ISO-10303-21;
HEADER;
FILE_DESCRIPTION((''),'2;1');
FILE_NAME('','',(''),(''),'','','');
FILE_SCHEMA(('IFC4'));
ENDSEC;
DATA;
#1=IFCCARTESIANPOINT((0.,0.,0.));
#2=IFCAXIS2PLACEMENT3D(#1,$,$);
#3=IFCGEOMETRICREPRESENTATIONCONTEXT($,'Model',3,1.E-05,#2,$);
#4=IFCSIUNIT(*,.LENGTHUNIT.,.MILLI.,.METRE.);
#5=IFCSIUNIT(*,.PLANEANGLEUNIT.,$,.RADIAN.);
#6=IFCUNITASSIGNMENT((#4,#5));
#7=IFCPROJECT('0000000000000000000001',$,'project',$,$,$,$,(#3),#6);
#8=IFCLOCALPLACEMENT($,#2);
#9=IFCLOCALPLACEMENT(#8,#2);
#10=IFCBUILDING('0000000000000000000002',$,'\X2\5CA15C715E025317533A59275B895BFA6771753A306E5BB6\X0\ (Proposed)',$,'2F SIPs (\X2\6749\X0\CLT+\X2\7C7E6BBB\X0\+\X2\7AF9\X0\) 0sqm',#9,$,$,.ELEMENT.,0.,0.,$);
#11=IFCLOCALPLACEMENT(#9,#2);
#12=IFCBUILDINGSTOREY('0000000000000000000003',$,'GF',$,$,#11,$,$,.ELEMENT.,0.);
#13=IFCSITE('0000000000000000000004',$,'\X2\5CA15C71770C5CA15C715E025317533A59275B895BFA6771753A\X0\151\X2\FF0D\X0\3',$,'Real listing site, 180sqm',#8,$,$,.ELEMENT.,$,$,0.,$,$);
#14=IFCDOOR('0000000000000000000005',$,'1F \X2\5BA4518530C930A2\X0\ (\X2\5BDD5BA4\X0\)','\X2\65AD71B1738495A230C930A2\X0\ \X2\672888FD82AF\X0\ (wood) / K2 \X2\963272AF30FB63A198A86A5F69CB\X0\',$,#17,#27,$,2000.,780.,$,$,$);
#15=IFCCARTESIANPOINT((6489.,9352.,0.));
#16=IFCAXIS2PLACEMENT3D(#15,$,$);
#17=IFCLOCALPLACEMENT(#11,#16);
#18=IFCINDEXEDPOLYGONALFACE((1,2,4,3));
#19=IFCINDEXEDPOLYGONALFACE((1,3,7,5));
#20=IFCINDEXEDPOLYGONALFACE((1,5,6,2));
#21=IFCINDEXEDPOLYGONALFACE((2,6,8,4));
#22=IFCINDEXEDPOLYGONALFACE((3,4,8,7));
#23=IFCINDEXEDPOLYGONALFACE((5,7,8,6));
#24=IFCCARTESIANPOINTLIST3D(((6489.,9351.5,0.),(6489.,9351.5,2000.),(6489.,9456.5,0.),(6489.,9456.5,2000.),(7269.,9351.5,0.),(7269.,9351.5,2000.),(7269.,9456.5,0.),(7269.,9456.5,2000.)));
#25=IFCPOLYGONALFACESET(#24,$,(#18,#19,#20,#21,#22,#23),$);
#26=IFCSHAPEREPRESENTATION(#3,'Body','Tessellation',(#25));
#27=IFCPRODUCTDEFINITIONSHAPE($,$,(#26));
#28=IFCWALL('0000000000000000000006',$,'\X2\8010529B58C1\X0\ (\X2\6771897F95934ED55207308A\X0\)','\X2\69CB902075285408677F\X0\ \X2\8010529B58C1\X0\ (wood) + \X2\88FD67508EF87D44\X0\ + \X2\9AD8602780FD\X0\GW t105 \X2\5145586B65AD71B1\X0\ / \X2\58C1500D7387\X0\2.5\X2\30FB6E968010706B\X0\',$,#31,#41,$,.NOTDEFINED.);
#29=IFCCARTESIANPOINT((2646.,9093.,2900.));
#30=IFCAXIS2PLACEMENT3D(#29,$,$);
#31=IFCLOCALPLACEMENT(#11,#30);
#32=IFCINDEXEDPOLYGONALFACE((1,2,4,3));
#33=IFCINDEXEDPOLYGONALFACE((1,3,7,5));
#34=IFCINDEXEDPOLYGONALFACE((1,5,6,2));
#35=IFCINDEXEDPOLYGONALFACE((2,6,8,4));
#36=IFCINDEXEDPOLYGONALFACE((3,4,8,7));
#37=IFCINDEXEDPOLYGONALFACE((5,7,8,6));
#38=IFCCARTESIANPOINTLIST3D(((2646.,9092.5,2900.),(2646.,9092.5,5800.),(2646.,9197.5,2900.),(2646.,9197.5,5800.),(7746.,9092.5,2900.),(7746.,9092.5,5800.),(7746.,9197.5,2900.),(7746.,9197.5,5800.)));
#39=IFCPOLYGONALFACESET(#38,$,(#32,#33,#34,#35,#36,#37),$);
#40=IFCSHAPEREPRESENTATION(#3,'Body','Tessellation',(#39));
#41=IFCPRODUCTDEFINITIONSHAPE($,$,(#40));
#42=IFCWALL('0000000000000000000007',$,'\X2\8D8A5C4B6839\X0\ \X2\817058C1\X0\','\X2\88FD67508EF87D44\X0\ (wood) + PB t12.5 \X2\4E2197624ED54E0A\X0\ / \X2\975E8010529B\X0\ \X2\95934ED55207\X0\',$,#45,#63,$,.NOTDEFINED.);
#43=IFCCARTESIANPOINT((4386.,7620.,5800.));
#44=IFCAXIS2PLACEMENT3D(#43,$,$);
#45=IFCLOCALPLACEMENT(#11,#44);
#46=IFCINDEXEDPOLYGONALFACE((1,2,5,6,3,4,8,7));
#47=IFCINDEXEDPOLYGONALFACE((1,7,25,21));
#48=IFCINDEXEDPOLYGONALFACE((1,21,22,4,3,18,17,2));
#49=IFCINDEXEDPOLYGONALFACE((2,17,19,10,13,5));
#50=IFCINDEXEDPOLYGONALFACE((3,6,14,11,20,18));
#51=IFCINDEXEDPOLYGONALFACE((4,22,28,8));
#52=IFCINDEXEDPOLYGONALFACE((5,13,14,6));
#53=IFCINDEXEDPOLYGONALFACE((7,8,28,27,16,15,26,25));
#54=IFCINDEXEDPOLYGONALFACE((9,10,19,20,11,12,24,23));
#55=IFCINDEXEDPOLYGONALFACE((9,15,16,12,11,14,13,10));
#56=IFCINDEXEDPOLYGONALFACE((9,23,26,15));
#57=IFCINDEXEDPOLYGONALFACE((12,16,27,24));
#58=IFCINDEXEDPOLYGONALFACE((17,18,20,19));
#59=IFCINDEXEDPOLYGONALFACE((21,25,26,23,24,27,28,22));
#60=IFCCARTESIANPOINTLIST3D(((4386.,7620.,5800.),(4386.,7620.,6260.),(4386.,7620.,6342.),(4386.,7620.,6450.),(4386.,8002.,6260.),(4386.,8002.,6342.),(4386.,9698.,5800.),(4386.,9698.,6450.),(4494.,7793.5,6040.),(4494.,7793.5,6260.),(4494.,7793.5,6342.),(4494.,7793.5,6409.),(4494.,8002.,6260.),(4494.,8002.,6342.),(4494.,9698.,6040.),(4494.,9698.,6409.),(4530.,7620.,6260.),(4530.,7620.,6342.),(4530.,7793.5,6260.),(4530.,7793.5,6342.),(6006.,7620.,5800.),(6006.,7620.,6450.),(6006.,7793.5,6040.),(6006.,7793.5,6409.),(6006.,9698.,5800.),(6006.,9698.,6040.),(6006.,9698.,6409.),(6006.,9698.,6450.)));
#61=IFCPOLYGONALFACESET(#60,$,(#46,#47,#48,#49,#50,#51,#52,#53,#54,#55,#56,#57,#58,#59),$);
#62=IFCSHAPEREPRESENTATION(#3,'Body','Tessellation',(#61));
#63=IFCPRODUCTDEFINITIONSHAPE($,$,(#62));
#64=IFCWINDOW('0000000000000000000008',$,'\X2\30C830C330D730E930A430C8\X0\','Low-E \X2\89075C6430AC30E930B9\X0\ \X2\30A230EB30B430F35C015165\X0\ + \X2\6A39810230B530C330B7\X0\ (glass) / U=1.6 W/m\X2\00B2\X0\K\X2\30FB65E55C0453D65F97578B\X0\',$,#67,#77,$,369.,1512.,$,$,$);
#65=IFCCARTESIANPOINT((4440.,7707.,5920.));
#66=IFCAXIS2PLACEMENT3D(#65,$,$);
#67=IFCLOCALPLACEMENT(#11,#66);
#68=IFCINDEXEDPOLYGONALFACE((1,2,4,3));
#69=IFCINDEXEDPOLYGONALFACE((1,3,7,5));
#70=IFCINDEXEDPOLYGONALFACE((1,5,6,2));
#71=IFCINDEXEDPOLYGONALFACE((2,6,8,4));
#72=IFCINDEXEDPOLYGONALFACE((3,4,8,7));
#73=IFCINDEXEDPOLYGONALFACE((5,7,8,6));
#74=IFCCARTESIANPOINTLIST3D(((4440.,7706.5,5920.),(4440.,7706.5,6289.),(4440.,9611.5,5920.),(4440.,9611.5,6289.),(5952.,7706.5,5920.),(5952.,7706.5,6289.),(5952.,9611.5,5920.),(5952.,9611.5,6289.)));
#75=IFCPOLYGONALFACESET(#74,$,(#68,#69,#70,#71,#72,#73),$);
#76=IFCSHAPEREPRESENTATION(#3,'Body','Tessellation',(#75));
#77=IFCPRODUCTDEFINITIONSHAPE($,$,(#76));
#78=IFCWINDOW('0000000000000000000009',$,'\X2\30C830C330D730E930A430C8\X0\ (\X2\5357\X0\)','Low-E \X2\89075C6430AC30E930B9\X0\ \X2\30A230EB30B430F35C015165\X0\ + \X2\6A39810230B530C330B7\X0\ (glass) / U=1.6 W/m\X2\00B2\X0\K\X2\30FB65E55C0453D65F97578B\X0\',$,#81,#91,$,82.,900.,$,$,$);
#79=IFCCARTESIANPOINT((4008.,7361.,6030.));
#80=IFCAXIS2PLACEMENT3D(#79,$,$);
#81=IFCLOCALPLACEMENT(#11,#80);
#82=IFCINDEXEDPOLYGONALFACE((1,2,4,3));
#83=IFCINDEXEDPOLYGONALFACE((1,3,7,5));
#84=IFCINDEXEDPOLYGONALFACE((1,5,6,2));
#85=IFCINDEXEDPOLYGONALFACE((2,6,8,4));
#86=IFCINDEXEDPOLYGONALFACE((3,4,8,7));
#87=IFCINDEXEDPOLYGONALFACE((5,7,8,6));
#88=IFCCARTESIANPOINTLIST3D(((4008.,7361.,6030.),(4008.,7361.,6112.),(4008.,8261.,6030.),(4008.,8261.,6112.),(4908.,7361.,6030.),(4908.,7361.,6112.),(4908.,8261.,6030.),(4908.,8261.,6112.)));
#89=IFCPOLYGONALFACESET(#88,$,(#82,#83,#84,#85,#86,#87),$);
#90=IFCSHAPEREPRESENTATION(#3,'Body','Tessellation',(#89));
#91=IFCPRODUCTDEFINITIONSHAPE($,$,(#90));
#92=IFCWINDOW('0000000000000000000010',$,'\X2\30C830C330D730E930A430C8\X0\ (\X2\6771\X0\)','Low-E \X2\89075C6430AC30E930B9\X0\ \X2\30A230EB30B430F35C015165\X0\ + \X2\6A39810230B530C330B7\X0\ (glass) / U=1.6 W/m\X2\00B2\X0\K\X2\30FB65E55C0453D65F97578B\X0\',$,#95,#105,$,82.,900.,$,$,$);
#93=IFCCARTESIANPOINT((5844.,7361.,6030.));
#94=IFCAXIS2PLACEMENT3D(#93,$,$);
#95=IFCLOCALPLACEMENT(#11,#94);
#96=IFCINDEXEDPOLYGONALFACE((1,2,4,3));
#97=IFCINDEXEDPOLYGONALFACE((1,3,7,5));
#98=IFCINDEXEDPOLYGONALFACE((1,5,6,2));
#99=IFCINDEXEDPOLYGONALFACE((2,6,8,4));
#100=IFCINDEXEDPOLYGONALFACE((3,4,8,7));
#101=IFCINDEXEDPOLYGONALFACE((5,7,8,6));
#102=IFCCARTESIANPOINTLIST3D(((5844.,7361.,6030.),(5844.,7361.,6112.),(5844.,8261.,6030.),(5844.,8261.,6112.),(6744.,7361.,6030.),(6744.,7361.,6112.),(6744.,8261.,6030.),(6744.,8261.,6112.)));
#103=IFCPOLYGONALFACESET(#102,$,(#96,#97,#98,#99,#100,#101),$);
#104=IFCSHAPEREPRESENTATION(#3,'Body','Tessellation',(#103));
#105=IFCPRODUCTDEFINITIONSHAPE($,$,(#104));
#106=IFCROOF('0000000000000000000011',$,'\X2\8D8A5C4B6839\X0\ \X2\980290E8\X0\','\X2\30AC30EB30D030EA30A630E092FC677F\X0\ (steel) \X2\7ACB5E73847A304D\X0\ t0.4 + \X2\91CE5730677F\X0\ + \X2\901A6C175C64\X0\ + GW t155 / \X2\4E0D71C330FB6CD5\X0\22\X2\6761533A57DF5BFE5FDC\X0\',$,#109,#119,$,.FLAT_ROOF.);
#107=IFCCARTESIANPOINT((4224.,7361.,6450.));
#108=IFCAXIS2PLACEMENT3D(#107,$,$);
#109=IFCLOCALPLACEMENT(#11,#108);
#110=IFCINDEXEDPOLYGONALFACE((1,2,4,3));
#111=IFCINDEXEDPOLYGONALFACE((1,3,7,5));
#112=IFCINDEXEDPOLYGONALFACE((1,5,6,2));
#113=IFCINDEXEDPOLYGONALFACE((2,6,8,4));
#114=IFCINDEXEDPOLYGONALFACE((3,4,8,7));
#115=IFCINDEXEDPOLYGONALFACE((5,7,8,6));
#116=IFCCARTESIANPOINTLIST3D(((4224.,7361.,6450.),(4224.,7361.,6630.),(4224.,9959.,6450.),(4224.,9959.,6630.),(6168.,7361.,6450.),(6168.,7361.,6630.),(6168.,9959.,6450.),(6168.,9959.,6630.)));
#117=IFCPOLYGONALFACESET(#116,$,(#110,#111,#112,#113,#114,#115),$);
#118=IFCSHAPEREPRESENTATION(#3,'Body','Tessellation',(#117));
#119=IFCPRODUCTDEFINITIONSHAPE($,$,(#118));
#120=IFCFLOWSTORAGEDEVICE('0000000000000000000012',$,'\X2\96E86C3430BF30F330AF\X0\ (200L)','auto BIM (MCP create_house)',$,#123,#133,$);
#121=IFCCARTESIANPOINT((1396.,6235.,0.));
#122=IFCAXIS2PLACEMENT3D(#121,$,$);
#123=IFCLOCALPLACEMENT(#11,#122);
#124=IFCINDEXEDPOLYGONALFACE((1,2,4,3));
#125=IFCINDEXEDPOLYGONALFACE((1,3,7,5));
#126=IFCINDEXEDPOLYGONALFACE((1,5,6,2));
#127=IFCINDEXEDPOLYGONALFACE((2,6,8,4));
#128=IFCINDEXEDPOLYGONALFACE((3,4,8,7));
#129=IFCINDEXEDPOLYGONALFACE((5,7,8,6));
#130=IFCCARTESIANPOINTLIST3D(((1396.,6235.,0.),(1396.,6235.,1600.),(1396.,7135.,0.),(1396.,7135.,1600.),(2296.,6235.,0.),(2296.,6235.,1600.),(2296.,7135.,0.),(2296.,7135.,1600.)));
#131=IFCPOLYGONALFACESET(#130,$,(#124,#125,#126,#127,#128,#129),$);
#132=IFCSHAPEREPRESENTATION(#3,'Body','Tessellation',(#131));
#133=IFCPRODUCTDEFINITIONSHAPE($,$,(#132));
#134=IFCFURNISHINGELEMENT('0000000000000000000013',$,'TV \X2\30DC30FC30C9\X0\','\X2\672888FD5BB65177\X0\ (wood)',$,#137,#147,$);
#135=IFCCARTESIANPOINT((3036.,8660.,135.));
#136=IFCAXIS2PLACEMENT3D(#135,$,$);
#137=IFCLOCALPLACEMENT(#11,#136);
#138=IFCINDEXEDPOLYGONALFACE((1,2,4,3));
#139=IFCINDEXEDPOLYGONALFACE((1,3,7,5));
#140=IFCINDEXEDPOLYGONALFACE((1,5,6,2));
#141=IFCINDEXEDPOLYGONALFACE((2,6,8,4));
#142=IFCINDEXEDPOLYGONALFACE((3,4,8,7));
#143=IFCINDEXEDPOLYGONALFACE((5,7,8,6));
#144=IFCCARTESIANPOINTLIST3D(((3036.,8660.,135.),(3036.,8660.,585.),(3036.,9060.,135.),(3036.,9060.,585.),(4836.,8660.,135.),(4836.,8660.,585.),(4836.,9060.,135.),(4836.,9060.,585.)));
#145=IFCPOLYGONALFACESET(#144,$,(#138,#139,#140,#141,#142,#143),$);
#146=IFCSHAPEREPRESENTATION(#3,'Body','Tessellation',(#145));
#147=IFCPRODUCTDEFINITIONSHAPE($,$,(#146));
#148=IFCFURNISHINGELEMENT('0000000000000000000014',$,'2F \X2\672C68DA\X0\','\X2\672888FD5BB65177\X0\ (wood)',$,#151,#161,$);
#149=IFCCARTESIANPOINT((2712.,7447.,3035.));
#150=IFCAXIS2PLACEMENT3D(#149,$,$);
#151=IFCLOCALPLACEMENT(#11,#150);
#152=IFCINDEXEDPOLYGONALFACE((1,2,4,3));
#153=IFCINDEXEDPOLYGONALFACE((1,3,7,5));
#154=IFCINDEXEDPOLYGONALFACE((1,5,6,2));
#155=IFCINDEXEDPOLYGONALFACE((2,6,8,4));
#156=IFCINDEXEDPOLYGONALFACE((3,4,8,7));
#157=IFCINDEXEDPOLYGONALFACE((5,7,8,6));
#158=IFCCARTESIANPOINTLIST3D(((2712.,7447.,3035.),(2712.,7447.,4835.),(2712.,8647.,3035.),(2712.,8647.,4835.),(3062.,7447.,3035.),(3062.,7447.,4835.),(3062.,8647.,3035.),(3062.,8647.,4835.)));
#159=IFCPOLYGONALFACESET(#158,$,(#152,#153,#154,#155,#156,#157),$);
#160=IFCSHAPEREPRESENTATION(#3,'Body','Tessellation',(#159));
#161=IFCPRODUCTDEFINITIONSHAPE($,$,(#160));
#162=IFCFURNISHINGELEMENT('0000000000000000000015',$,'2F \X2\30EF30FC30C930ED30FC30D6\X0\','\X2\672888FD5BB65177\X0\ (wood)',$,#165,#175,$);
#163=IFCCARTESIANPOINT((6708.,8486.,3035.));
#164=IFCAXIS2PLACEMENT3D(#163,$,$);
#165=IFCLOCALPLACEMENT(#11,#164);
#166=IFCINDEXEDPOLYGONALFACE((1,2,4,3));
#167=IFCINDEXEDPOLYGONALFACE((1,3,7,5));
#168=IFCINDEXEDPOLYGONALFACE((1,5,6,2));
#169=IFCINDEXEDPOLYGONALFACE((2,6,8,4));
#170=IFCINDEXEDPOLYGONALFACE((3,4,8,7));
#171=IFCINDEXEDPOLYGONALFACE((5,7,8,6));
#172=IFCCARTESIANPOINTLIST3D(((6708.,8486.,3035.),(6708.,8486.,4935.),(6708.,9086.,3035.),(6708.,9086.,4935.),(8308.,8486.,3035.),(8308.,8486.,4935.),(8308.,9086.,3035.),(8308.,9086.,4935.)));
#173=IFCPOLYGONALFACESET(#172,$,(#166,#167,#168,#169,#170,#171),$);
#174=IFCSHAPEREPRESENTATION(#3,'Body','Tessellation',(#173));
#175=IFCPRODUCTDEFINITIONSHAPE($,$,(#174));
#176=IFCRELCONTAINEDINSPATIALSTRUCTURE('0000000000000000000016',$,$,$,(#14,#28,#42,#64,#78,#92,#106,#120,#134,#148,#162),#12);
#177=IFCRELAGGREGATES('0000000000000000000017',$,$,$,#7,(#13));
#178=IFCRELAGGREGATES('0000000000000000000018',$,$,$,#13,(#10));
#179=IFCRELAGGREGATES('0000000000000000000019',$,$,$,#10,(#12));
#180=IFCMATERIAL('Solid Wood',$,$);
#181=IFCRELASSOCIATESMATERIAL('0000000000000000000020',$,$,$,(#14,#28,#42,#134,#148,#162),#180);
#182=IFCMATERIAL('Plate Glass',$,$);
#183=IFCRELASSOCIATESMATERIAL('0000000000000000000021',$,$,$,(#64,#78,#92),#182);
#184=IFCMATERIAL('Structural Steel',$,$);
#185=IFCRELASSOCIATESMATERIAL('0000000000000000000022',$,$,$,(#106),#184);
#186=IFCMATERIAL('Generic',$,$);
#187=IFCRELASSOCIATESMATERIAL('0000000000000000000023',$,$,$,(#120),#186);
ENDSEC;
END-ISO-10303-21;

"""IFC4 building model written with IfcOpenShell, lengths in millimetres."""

from ifc_helpers import new_model, si_unit, frame, frame_2d, origin, place, context, project, spatial, rectangle, extrude, material, element, fill, save


model = new_model("IFC4")

# Units and contexts
model_context = context("Model", 3, precision=1e-05, world=origin())
ifc_project = project(units=[si_unit("LENGTHUNIT", "METRE", prefix="MILLI"), si_unit("PLANEANGLEUNIT", "RADIAN")], contexts=[model_context])

# Site, building, storey
site_placement = place(None, origin())
site = spatial("IfcSite", under=ifc_project, at=site_placement, Name="岡山県岡山市北区大安寺東町151－3", ObjectType="Real listing site, 180sqm", CompositionType="ELEMENT", RefElevation=0.0)
building_placement = place(site_placement, origin())
building = spatial("IfcBuilding", under=site, at=building_placement, Name="岡山市北区大安寺東町の家 (Proposed)", ObjectType="2F SIPs (杉CLT+籾殻+竹) 0sqm", CompositionType="ELEMENT", ElevationOfRefHeight=0.0, ElevationOfTerrain=0.0)
storey_placement = place(building_placement, origin())
storey = spatial("IfcBuildingStorey", under=building, at=storey_placement, Name="GF", CompositionType="ELEMENT", Elevation=0.0)

# Shared definitions
ifc_material_1 = material(Name="Solid Wood")

# Door
door_placement = place(storey_placement, frame((6489.0, 9352.0, 0.0)))
element("IfcDoor", 1, at=door_placement, inside=storey, material=ifc_material_1, Name="1F 室内ドア (寝室)", Description="断熱玄関ドア 木製芯 (wood) / K2 防犯・採風機構", OverallHeight=2000.0, OverallWidth=780.0, context=model_context, shape_type="SweptSolid", body=[
    extrude(rectangle(XDim=780.0, YDim=105.0, at=frame_2d((390.0, 52.0))), frame((6489.0, 9352.0, 0.0)), (0.0, 0.0, 1.0), 2000.0),
])

# Wall
wall_1_placement = place(storey_placement, frame((2646.0, 9093.0, 2900.0)))
element("IfcWall", 2, at=wall_1_placement, inside=storey, material=ifc_material_1, Name="耐力壁 (東西間仕切り)", Description="構造用合板 耐力壁 (wood) + 製材軸組 + 高性能GW t105 充填断熱 / 壁倍率2.5・準耐火", PredefinedType="NOTDEFINED", context=model_context, shape_type="SweptSolid", body=[
    extrude(rectangle(XDim=5100.0, YDim=105.0, at=frame_2d((2550.0, 52.0))), frame((2646.0, 9093.0, 2900.0)), (0.0, 0.0, 1.0), 2900.0),
])

# Wall, openings, windows
wall_2_placement = place(storey_placement, frame((4386.0, 7620.0, 5800.0)))
wall_2 = element("IfcWall", 3, at=wall_2_placement, inside=storey, material=ifc_material_1, Name="越屋根 腰壁", Description="製材軸組 (wood) + PB t12.5 両面仕上 / 非耐力 間仕切", PredefinedType="NOTDEFINED", context=model_context, shape_type="SweptSolid", body=[
    extrude(rectangle(XDim=1620.0, YDim=2078.0, at=frame_2d((810.0, 1039.0))), frame((4386.0, 7620.0, 5800.0)), (0.0, 0.0, 1.0), 650.0),
])
opening_1_placement = place(storey_placement, frame((4440.0, 7707.0, 5920.0)))
opening_1 = element("IfcOpeningElement", 4, at=opening_1_placement, cuts=wall_2, PredefinedType="NOTDEFINED", context=model_context, shape_type="SweptSolid", body=[
    extrude(rectangle(XDim=1512.0, YDim=1905.0, at=frame_2d((756.0, 952.0))), frame((4440.0, 7707.0, 5920.0)), (0.0, 0.0, 1.0), 369.0),
])
opening_2_placement = place(storey_placement, frame((4008.0, 7361.0, 6030.0)))
opening_2 = element("IfcOpeningElement", 5, at=opening_2_placement, cuts=wall_2, PredefinedType="NOTDEFINED", context=model_context, shape_type="SweptSolid", body=[
    extrude(rectangle(XDim=900.0, YDim=900.0, at=frame_2d((450.0, 450.0))), frame((4008.0, 7361.0, 6030.0)), (0.0, 0.0, 1.0), 82.0),
])
opening_3_placement = place(storey_placement, frame((5844.0, 7361.0, 6030.0)))
opening_3 = element("IfcOpeningElement", 6, at=opening_3_placement, cuts=wall_2, PredefinedType="NOTDEFINED", context=model_context, shape_type="SweptSolid", body=[
    extrude(rectangle(XDim=900.0, YDim=900.0, at=frame_2d((450.0, 450.0))), frame((5844.0, 7361.0, 6030.0)), (0.0, 0.0, 1.0), 82.0),
])
ifc_material_2 = material(Name="Plate Glass")
window_1_placement = place(storey_placement, frame((4440.0, 7707.0, 5920.0)))
window_1 = element("IfcWindow", 7, at=window_1_placement, inside=storey, material=ifc_material_2, Name="トップライト", Description="Low-E 複層ガラス アルゴン封入 + 樹脂サッシ (glass) / U=1.6 W/m²K・日射取得型", OverallHeight=369.0, OverallWidth=1512.0, context=model_context, shape_type="SweptSolid", body=[
    extrude(rectangle(XDim=1512.0, YDim=1905.0, at=frame_2d((756.0, 952.0))), frame((4440.0, 7707.0, 5920.0)), (0.0, 0.0, 1.0), 369.0),
])
fill(opening_1, window_1)
window_2_placement = place(storey_placement, frame((4008.0, 7361.0, 6030.0)))
window_2 = element("IfcWindow", 8, at=window_2_placement, inside=storey, material=ifc_material_2, Name="トップライト (南)", Description="Low-E 複層ガラス アルゴン封入 + 樹脂サッシ (glass) / U=1.6 W/m²K・日射取得型", OverallHeight=82.0, OverallWidth=900.0, context=model_context, shape_type="SweptSolid", body=[
    extrude(rectangle(XDim=900.0, YDim=900.0, at=frame_2d((450.0, 450.0))), frame((4008.0, 7361.0, 6030.0)), (0.0, 0.0, 1.0), 82.0),
])
fill(opening_2, window_2)
window_3_placement = place(storey_placement, frame((5844.0, 7361.0, 6030.0)))
window_3 = element("IfcWindow", 9, at=window_3_placement, inside=storey, material=ifc_material_2, Name="トップライト (東)", Description="Low-E 複層ガラス アルゴン封入 + 樹脂サッシ (glass) / U=1.6 W/m²K・日射取得型", OverallHeight=82.0, OverallWidth=900.0, context=model_context, shape_type="SweptSolid", body=[
    extrude(rectangle(XDim=900.0, YDim=900.0, at=frame_2d((450.0, 450.0))), frame((5844.0, 7361.0, 6030.0)), (0.0, 0.0, 1.0), 82.0),
])
fill(opening_3, window_3)

# Roof
ifc_material_3 = material(Name="Structural Steel")
roof_placement = place(storey_placement, frame((4224.0, 7361.0, 6450.0)))
element("IfcRoof", 10, at=roof_placement, inside=storey, material=ifc_material_3, Name="越屋根 頂部", Description="ガルバリウム鋼板 (steel) 立平葺き t0.4 + 野地板 + 通気層 + GW t155 / 不燃・法22条区域対応", PredefinedType="FLAT_ROOF", context=model_context, shape_type="SweptSolid", body=[
    extrude(rectangle(XDim=1944.0, YDim=2598.0, at=frame_2d((972.0, 1299.0))), frame((4224.0, 7361.0, 6450.0)), (0.0, 0.0, 1.0), 180.0),
])

# Flow storage device
ifc_material_4 = material(Name="Generic")
flow_storage_device_placement = place(storey_placement, frame((1396.0, 6235.0, 0.0)))
element("IfcFlowStorageDevice", 11, at=flow_storage_device_placement, inside=storey, material=ifc_material_4, Name="雨水タンク (200L)", Description="auto BIM (MCP create_house)", context=model_context, shape_type="SweptSolid", body=[
    extrude(rectangle(XDim=900.0, YDim=900.0, at=frame_2d((450.0, 450.0))), frame((1396.0, 6235.0, 0.0)), (0.0, 0.0, 1.0), 1600.0),
])

# Furnishing elements
furnishing_1_placement = place(storey_placement, frame((3036.0, 8660.0, 135.0)))
element("IfcFurnishingElement", 12, at=furnishing_1_placement, inside=storey, material=ifc_material_1, Name="TV ボード", Description="木製家具 (wood)", context=model_context, shape_type="SweptSolid", body=[
    extrude(rectangle(XDim=1800.0, YDim=400.0, at=frame_2d((900.0, 200.0))), frame((3036.0, 8660.0, 135.0)), (0.0, 0.0, 1.0), 450.0),
])
furnishing_2_placement = place(storey_placement, frame((2712.0, 7447.0, 3035.0)))
element("IfcFurnishingElement", 13, at=furnishing_2_placement, inside=storey, material=ifc_material_1, Name="2F 本棚", Description="木製家具 (wood)", context=model_context, shape_type="SweptSolid", body=[
    extrude(rectangle(XDim=350.0, YDim=1200.0, at=frame_2d((175.0, 600.0))), frame((2712.0, 7447.0, 3035.0)), (0.0, 0.0, 1.0), 1800.0),
])
furnishing_3_placement = place(storey_placement, frame((6708.0, 8486.0, 3035.0)))
element("IfcFurnishingElement", 14, at=furnishing_3_placement, inside=storey, material=ifc_material_1, Name="2F ワードローブ", Description="木製家具 (wood)", context=model_context, shape_type="SweptSolid", body=[
    extrude(rectangle(XDim=1600.0, YDim=600.0, at=frame_2d((800.0, 300.0))), frame((6708.0, 8486.0, 3035.0)), (0.0, 0.0, 1.0), 1900.0),
])

save(model, "model.ifc")
